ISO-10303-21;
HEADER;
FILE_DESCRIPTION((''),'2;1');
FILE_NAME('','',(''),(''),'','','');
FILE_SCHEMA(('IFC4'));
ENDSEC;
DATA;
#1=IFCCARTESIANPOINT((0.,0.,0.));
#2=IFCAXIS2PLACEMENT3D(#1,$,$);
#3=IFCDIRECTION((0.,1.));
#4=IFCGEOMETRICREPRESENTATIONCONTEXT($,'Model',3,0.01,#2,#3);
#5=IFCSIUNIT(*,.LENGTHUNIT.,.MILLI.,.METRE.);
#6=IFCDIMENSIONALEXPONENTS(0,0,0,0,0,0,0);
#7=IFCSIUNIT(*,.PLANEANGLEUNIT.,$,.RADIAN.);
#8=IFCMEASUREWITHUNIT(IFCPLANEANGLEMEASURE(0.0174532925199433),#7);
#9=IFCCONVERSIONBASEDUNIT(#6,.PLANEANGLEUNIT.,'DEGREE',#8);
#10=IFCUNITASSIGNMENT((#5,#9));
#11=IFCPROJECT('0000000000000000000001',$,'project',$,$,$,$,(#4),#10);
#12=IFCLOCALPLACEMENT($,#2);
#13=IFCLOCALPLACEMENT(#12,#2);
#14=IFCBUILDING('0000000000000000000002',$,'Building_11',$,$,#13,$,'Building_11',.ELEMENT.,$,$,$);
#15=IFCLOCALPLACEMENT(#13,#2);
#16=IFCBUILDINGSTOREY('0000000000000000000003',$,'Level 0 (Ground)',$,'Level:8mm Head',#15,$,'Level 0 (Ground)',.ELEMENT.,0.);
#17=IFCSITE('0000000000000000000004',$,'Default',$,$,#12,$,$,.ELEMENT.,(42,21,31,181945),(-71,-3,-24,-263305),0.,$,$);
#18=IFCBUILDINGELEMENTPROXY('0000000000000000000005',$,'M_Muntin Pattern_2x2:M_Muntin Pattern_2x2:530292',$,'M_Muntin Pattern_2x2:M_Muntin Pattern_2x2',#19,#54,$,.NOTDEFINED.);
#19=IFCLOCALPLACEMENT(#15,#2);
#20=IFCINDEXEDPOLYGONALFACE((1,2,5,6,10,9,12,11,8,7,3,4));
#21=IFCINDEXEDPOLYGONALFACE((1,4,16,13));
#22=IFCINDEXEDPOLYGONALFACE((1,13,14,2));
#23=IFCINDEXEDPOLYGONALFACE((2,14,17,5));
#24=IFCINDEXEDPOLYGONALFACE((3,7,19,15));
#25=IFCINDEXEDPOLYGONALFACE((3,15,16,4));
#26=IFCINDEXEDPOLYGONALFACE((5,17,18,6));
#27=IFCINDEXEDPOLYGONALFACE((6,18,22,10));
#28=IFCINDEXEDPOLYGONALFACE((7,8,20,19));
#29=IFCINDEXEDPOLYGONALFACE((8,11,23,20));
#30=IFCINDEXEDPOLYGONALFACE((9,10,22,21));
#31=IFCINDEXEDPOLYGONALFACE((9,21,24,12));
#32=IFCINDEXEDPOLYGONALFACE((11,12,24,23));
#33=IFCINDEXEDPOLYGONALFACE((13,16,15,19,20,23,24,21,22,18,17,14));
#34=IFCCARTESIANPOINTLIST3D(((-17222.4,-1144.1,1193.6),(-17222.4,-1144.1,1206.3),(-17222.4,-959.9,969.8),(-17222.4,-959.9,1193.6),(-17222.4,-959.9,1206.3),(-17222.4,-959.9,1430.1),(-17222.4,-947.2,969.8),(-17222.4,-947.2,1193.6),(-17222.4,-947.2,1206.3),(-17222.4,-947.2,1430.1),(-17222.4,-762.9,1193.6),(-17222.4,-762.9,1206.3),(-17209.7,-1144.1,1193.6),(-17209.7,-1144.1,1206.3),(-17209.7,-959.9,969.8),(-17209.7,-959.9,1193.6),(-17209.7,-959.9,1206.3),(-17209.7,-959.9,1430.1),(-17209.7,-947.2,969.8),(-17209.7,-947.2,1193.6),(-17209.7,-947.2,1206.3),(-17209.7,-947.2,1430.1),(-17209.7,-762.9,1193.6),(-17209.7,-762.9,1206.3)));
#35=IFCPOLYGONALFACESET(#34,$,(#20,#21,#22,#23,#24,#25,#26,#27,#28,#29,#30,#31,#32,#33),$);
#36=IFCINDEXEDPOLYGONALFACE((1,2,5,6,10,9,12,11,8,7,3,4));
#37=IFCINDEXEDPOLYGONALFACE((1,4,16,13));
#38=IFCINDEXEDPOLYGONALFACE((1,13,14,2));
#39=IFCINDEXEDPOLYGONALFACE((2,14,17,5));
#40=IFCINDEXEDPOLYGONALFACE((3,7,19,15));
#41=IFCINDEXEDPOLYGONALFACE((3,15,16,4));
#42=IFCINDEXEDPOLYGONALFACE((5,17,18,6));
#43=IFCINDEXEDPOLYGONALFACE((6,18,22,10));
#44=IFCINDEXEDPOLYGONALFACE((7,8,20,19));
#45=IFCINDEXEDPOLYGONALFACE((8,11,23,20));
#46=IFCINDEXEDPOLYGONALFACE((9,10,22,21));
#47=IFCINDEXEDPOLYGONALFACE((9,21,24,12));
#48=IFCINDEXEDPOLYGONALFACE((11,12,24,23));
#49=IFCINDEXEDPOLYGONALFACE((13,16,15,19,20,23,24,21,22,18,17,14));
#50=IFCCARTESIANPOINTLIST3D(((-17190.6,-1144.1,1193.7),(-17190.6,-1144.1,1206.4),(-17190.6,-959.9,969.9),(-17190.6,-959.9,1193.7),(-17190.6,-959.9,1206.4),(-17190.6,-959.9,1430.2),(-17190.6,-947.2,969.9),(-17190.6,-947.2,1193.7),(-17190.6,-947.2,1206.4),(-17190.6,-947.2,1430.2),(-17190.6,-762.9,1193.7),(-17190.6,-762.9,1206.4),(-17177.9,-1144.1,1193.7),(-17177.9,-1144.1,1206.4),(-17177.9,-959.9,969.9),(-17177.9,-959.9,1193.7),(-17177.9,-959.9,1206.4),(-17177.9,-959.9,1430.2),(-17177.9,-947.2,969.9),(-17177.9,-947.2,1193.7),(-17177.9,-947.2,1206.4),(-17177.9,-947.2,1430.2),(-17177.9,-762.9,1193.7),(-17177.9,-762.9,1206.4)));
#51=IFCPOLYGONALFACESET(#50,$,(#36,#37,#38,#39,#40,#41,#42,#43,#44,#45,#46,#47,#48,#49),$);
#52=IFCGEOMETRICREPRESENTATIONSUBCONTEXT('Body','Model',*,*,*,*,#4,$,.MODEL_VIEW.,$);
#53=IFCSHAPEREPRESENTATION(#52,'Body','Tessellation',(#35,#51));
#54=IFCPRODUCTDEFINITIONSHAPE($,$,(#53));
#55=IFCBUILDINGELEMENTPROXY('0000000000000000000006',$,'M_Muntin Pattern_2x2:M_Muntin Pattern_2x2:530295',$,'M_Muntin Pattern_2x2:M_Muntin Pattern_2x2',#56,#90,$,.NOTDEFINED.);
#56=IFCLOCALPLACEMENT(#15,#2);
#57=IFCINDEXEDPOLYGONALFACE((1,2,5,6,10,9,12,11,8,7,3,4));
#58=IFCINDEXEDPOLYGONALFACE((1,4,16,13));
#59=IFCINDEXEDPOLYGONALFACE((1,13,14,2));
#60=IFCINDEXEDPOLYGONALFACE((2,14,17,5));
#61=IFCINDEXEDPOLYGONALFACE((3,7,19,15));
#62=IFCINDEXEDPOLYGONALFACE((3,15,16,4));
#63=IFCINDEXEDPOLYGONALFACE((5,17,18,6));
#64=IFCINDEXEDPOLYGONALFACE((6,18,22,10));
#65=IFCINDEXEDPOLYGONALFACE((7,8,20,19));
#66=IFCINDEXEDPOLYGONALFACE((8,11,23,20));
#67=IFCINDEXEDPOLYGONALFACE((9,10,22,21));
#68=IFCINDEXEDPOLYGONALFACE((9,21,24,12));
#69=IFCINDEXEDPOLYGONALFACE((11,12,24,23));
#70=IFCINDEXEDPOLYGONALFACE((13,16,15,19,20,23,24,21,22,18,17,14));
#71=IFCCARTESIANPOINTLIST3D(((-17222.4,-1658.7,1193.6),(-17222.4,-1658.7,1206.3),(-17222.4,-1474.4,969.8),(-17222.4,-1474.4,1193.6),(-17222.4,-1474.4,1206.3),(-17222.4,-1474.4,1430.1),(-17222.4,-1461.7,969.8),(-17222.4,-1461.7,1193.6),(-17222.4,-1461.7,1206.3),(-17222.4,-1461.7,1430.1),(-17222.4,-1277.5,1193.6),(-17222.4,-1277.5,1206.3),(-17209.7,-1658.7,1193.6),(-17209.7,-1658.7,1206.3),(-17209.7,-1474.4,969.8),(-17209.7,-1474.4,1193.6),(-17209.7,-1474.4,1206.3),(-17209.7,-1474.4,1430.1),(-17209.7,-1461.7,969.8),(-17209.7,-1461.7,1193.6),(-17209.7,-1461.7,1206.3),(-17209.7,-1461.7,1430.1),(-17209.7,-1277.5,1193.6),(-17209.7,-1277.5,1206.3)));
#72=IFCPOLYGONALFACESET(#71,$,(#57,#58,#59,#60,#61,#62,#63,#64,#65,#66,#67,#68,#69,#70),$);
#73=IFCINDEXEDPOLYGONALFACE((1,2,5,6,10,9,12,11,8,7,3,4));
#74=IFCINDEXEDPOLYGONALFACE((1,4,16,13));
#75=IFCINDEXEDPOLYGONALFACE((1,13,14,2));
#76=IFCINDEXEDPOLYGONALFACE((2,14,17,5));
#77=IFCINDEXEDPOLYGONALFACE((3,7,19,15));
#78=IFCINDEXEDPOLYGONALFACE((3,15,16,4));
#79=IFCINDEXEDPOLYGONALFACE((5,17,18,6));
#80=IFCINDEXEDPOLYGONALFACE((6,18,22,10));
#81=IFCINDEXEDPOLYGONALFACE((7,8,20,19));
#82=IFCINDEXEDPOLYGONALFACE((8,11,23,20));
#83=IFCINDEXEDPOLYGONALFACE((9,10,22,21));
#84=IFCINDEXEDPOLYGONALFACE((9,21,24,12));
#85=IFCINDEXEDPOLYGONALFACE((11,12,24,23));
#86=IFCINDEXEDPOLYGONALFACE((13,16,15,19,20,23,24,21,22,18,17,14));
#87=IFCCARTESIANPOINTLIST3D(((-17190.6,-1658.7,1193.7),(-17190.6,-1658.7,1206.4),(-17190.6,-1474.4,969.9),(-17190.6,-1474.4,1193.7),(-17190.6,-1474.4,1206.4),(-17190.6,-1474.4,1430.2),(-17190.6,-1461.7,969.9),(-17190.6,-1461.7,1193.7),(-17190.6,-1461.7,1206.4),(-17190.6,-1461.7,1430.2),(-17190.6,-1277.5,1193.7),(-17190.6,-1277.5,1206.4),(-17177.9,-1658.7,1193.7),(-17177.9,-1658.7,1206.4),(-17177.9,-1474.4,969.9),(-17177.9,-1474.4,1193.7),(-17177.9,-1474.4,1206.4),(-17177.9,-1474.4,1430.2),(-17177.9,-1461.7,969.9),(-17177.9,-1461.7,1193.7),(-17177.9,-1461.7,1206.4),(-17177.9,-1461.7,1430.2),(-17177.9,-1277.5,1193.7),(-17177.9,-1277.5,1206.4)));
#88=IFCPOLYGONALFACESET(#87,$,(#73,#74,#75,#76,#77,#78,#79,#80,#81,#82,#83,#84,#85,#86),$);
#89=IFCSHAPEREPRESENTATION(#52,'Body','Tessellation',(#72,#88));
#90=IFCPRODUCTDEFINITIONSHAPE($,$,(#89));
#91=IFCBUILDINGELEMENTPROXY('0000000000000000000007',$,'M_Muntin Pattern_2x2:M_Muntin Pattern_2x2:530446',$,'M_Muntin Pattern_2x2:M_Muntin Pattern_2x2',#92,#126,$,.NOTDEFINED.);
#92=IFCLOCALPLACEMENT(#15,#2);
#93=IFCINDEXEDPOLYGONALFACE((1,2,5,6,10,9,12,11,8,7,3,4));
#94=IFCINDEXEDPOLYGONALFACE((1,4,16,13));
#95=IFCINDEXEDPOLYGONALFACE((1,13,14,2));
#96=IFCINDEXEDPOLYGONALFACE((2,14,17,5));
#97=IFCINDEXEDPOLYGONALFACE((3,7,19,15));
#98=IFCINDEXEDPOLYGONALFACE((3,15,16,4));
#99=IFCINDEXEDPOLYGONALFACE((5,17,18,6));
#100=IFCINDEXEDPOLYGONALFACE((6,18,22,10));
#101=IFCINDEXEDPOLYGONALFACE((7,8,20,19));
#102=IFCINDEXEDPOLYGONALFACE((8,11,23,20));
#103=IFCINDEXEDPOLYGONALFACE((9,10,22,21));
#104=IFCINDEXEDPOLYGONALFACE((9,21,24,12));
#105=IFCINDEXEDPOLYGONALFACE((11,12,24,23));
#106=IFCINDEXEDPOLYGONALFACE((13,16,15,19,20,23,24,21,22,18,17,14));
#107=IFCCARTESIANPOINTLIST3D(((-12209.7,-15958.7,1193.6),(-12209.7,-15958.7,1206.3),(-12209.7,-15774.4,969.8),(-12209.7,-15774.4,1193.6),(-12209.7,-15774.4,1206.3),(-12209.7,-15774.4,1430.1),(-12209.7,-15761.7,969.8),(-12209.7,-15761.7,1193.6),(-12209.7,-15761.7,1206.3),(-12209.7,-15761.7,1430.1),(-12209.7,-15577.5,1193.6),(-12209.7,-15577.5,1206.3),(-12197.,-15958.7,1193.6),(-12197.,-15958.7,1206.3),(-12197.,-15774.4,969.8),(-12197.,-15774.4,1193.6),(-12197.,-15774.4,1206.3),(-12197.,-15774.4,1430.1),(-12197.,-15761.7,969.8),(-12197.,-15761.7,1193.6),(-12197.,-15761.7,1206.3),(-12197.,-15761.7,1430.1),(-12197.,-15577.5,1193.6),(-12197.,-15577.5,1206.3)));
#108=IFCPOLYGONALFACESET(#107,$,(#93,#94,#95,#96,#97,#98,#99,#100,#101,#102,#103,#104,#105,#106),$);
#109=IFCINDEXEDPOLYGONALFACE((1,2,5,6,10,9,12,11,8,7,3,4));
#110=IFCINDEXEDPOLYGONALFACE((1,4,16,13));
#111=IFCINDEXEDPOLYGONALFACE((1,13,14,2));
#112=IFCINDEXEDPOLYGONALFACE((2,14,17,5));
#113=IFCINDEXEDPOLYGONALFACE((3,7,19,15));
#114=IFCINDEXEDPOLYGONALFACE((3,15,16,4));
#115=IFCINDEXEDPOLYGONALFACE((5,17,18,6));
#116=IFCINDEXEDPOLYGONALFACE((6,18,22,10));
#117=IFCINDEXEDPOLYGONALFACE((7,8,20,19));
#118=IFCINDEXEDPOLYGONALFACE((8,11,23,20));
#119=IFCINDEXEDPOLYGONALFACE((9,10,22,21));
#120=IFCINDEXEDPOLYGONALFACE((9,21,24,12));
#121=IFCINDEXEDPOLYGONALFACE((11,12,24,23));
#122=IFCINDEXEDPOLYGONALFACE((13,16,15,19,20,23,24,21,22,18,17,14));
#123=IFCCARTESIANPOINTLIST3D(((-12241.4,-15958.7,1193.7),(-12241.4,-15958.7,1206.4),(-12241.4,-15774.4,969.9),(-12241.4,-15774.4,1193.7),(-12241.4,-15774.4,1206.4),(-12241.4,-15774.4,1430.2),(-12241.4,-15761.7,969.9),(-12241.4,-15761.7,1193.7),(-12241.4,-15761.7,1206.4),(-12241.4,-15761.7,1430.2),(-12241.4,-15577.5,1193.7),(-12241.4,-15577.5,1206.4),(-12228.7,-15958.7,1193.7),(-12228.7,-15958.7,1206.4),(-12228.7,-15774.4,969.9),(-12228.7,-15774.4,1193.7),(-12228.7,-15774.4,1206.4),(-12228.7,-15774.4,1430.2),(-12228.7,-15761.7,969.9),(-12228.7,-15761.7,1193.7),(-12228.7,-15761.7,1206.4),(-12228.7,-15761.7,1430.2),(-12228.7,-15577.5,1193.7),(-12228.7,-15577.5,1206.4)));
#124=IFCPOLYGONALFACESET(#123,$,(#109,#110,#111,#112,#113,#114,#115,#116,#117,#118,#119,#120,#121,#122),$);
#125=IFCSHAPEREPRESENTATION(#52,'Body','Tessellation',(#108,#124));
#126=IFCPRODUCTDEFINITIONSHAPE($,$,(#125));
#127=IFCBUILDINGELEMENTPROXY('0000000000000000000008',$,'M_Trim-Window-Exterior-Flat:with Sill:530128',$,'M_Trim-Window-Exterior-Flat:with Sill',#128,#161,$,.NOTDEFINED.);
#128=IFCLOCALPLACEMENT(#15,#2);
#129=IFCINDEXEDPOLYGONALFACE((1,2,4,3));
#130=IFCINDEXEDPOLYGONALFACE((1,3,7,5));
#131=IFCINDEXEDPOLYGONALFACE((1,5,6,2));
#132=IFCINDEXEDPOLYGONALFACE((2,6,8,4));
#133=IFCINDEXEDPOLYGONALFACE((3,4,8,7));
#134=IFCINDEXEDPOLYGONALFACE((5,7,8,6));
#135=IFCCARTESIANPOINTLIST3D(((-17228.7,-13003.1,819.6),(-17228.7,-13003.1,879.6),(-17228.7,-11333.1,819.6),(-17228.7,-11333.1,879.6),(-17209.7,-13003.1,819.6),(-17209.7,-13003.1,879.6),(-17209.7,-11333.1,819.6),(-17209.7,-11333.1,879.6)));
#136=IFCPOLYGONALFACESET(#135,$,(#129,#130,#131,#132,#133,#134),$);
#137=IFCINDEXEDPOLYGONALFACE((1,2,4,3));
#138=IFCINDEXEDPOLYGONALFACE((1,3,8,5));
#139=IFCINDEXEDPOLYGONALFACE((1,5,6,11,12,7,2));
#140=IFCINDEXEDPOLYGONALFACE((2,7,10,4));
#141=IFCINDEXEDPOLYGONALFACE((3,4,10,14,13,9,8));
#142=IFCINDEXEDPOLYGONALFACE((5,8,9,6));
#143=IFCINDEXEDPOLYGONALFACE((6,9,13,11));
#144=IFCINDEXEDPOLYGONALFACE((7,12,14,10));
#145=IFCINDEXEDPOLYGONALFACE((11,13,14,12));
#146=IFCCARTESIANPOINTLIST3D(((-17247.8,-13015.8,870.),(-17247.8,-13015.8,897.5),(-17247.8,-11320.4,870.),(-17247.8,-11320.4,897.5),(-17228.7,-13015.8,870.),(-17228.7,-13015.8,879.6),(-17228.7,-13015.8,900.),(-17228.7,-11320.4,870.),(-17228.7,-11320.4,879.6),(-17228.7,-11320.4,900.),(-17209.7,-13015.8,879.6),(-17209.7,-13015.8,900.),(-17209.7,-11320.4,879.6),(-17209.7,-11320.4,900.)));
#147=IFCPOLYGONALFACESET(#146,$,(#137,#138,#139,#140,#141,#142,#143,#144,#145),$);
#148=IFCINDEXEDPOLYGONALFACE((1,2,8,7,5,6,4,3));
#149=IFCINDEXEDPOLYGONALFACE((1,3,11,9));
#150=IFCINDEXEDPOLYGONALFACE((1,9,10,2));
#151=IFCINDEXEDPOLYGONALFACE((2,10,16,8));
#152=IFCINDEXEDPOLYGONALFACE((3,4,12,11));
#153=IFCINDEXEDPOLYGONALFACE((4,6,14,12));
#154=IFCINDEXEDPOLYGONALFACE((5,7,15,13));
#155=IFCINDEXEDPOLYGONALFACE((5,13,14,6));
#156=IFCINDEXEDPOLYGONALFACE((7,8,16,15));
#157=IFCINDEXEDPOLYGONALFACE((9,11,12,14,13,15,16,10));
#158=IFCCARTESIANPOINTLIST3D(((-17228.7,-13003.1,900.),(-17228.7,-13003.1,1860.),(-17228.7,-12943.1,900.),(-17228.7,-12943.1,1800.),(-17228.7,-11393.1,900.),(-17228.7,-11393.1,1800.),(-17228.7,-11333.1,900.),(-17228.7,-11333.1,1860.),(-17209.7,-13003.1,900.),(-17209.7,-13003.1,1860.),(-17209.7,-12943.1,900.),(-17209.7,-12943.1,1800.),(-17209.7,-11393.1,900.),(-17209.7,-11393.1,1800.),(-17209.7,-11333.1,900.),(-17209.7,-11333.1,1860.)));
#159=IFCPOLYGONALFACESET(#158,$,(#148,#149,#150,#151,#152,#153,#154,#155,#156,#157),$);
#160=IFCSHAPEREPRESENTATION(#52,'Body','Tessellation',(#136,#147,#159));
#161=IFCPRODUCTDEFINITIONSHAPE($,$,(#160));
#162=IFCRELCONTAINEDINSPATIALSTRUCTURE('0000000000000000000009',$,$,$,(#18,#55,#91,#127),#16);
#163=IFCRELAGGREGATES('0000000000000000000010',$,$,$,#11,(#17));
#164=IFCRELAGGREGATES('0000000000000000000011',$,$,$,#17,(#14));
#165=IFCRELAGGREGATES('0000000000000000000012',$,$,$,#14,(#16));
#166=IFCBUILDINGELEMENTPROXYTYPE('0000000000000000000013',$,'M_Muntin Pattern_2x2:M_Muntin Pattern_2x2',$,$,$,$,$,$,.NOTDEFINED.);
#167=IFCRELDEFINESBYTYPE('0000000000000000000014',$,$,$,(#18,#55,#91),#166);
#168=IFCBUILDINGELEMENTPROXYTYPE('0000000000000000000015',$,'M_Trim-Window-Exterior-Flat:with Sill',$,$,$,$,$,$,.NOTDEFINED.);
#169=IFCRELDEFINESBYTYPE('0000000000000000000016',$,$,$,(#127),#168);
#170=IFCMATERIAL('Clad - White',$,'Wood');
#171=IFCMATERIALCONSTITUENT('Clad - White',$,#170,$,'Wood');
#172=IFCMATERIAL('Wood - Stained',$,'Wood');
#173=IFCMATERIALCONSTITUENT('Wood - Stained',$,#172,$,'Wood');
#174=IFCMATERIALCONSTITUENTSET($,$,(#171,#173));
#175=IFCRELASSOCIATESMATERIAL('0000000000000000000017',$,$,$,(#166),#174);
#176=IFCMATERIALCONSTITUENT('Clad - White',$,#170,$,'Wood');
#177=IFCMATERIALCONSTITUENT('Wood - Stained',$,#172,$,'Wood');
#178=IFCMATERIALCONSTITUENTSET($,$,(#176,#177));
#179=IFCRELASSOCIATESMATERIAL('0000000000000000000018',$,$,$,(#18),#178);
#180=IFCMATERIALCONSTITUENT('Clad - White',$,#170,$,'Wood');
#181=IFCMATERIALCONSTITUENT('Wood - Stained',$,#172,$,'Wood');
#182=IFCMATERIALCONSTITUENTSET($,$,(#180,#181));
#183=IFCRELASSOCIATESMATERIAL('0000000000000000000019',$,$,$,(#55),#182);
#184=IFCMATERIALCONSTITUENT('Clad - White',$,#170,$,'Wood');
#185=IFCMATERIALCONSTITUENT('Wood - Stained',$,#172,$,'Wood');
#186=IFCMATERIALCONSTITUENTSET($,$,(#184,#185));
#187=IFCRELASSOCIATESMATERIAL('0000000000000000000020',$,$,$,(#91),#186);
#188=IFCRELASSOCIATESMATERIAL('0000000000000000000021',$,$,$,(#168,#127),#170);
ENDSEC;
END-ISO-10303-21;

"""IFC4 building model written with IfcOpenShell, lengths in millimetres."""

from ifc_helpers import new_model, entity, si_unit, converted_unit, direction, frame, origin, place, context, subcontext, project, spatial, indexed_curve, outline, extrude, source, transform, mapped, material, constituent, constituent_set, type_object, type_shapes, element, save


model = new_model("IFC4")

# Units and contexts
model_context = context("Model", 3, precision=0.01, world=origin(), true_north=direction((0.0, 1.0)))
body_context = subcontext(model_context, "Body", "Model", "MODEL_VIEW")
ifc_project = project(units=[si_unit("LENGTHUNIT", "METRE", prefix="MILLI"), converted_unit("PLANEANGLEUNIT", "DEGREE", entity("IfcPlaneAngleMeasure", 0.0174532925199433), si_unit("PLANEANGLEUNIT", "RADIAN"), dimensions=[0, 0, 0, 0, 0, 0, 0])], contexts=[model_context])

# Site, building, storey
site_placement = place(None, origin())
site = spatial("IfcSite", under=ifc_project, at=site_placement, Name="Default", CompositionType="ELEMENT", RefLatitude=(42, 21, 31, 181945), RefLongitude=(-71, -3, -24, -263305), RefElevation=0.0)
building_placement = place(site_placement, origin())
building = spatial("IfcBuilding", under=site, at=building_placement, Name="Building_11", LongName="Building_11", CompositionType="ELEMENT")
storey_placement = place(building_placement, origin())
storey = spatial("IfcBuildingStorey", under=building, at=storey_placement, Name="Level 0 (Ground)", ObjectType="Level:8mm Head", LongName="Level 0 (Ground)", CompositionType="ELEMENT", Elevation=0.0)

# Building element proxies
ifc_material_1 = material(Name="Clad - White", Category="Wood")
ifc_material_2 = material(Name="Wood - Stained", Category="Wood")
ifc_constituent_1 = constituent(ifc_material_1, Name="Clad - White", Category="Wood")
ifc_constituent_2 = constituent(ifc_material_2, Name="Wood - Stained", Category="Wood")
ifc_constituent_set_1 = constituent_set(constituents=[ifc_constituent_1, ifc_constituent_2])
building_element_proxy_type_1 = type_object("IfcBuildingElementProxyType", Name="M_Muntin Pattern_2x2:M_Muntin Pattern_2x2", PredefinedType="NOTDEFINED", material=ifc_constituent_set_1)
shared_shape_1 = source(origin(), body_context, "Body", "SweptSolid", [
    extrude(outline(indexed_curve([(6.4, -6.4), (230.1, -6.4), (230.1, 6.3), (6.4, 6.3), (6.4, 190.6), (-6.3, 190.6), (-6.3, 6.3), (-230.2, 6.3), (-230.2, -6.4), (-6.3, -6.4), (-6.3, -190.6), (6.4, -190.6), (6.4, -6.4)], self_intersect=False)), frame((0.0, -22.2, 230.1), z_axis=(0.0, 1.0, 0.0), x_axis=(0.0, 0.0, 1.0)), (0.0, 0.0, 1.0), 12.7),
    extrude(outline(indexed_curve([(6.4, -6.4), (230.2, -6.4), (230.2, 6.3), (6.4, 6.3), (6.4, 190.6), (-6.3, 190.6), (-6.3, 6.3), (-230.2, 6.3), (-230.2, -6.4), (-6.3, -6.4), (-6.3, -190.6), (6.4, -190.6), (6.4, -6.4)], self_intersect=False)), frame((0.0, 9.5, 230.2), z_axis=(0.0, 1.0, 0.0), x_axis=(0.0, 0.0, 1.0)), (0.0, 0.0, 1.0), 12.7),
])
type_shapes(building_element_proxy_type_1, [shared_shape_1])
ifc_constituent_3 = constituent(ifc_material_1, Name="Clad - White", Category="Wood")
ifc_constituent_4 = constituent(ifc_material_2, Name="Wood - Stained", Category="Wood")
ifc_constituent_set_2 = constituent_set(constituents=[ifc_constituent_3, ifc_constituent_4])
proxy_1_placement = place(storey_placement, frame((-17200.2, -953.5, 969.9), z_axis=(0.0, 0.0, 1.0), x_axis=(0.0, -1.0, 0.0)))
element("IfcBuildingElementProxy", 1, at=proxy_1_placement, inside=storey, type_object=building_element_proxy_type_1, material=ifc_constituent_set_2, Name="M_Muntin Pattern_2x2:M_Muntin Pattern_2x2:530292", ObjectType="M_Muntin Pattern_2x2:M_Muntin Pattern_2x2", PredefinedType="NOTDEFINED", context=body_context, shape_type="MappedRepresentation", body=[
    mapped(shared_shape_1, transform((0.0, 0.0, 0.0), scale=1.0)),
])
ifc_constituent_5 = constituent(ifc_material_1, Name="Clad - White", Category="Wood")
ifc_constituent_6 = constituent(ifc_material_2, Name="Wood - Stained", Category="Wood")
ifc_constituent_set_3 = constituent_set(constituents=[ifc_constituent_5, ifc_constituent_6])
proxy_2_placement = place(storey_placement, frame((-17200.2, -1468.1, 969.9), z_axis=(0.0, 0.0, 1.0), x_axis=(0.0, -1.0, 0.0)))
element("IfcBuildingElementProxy", 2, at=proxy_2_placement, inside=storey, type_object=building_element_proxy_type_1, material=ifc_constituent_set_3, Name="M_Muntin Pattern_2x2:M_Muntin Pattern_2x2:530295", ObjectType="M_Muntin Pattern_2x2:M_Muntin Pattern_2x2", PredefinedType="NOTDEFINED", context=body_context, shape_type="MappedRepresentation", body=[
    mapped(shared_shape_1, transform((0.0, 0.0, 0.0), scale=1.0)),
])
ifc_constituent_7 = constituent(ifc_material_1, Name="Clad - White", Category="Wood")
ifc_constituent_8 = constituent(ifc_material_2, Name="Wood - Stained", Category="Wood")
ifc_constituent_set_4 = constituent_set(constituents=[ifc_constituent_7, ifc_constituent_8])
proxy_3_placement = place(storey_placement, frame((-12219.2, -15768.1, 969.9), z_axis=(0.0, 0.0, 1.0), x_axis=(0.0, 1.0, 0.0)))
element("IfcBuildingElementProxy", 3, at=proxy_3_placement, inside=storey, type_object=building_element_proxy_type_1, material=ifc_constituent_set_4, Name="M_Muntin Pattern_2x2:M_Muntin Pattern_2x2:530446", ObjectType="M_Muntin Pattern_2x2:M_Muntin Pattern_2x2", PredefinedType="NOTDEFINED", context=body_context, shape_type="MappedRepresentation", body=[
    mapped(shared_shape_1, transform((0.0, 0.0, 0.0), scale=1.0)),
])
building_element_proxy_type_2 = type_object("IfcBuildingElementProxyType", Name="M_Trim-Window-Exterior-Flat:with Sill", PredefinedType="NOTDEFINED", material=ifc_material_1)
shared_shape_2 = source(origin(), body_context, "Body", "SweptSolid", [
    extrude(outline(indexed_curve([(-835.0, -30.0), (835.0, -30.0), (835.0, 30.0), (-835.0, 30.0), (-835.0, -30.0)], self_intersect=False)), frame((0.0, -950.4, 0.0), z_axis=(0.0, 0.0, 1.0), x_axis=(-1.0, 0.0, 0.0)), (0.0, 0.0, 1.0), 19.1),
    extrude(outline(indexed_curve([(-19.0, -15.2), (0.0, -15.2), (0.0, -5.7), (19.0, -5.7), (19.0, 14.8), (0.0, 14.8), (-19.0, 12.3), (-19.0, -15.2)], self_intersect=False)), frame((-847.7, -914.8, 19.0), z_axis=(1.0, 0.0, 0.0), x_axis=(0.0, 0.0, -1.0)), (0.0, 0.0, 1.0), 1695.4),
    extrude(outline(indexed_curve([(-495.0, -835.0), (465.0, -835.0), (465.0, -775.0), (-435.0, -775.0), (-435.0, 775.0), (465.0, 775.0), (465.0, 835.0), (-495.0, 835.0), (-495.0, -835.0)], self_intersect=False)), frame((0.0, -435.0, 0.0), z_axis=(0.0, 0.0, 1.0), x_axis=(0.0, -1.0, 0.0)), (0.0, 0.0, 1.0), 19.1),
])
type_shapes(building_element_proxy_type_2, [shared_shape_2])
for number, where, z_axis, x_axis, name in (
    (4, (-17209.7, -12168.1, 1800.0), (-1.0, 0.0, 0.0), (0.0, -1.0, 0.0), "M_Trim-Window-Exterior-Flat:with Sill:530128"),
):
    element("IfcBuildingElementProxy", number, at=place(storey_placement, frame(where, z_axis=z_axis, x_axis=x_axis)), inside=storey, type_object=building_element_proxy_type_2, material=ifc_material_1, Name=name, ObjectType="M_Trim-Window-Exterior-Flat:with Sill", PredefinedType="NOTDEFINED", context=body_context, shape_type="MappedRepresentation", body=[
        mapped(shared_shape_2, transform((0.0, 0.0, 0.0), scale=1.0)),
    ])

save(model, "model.ifc")
